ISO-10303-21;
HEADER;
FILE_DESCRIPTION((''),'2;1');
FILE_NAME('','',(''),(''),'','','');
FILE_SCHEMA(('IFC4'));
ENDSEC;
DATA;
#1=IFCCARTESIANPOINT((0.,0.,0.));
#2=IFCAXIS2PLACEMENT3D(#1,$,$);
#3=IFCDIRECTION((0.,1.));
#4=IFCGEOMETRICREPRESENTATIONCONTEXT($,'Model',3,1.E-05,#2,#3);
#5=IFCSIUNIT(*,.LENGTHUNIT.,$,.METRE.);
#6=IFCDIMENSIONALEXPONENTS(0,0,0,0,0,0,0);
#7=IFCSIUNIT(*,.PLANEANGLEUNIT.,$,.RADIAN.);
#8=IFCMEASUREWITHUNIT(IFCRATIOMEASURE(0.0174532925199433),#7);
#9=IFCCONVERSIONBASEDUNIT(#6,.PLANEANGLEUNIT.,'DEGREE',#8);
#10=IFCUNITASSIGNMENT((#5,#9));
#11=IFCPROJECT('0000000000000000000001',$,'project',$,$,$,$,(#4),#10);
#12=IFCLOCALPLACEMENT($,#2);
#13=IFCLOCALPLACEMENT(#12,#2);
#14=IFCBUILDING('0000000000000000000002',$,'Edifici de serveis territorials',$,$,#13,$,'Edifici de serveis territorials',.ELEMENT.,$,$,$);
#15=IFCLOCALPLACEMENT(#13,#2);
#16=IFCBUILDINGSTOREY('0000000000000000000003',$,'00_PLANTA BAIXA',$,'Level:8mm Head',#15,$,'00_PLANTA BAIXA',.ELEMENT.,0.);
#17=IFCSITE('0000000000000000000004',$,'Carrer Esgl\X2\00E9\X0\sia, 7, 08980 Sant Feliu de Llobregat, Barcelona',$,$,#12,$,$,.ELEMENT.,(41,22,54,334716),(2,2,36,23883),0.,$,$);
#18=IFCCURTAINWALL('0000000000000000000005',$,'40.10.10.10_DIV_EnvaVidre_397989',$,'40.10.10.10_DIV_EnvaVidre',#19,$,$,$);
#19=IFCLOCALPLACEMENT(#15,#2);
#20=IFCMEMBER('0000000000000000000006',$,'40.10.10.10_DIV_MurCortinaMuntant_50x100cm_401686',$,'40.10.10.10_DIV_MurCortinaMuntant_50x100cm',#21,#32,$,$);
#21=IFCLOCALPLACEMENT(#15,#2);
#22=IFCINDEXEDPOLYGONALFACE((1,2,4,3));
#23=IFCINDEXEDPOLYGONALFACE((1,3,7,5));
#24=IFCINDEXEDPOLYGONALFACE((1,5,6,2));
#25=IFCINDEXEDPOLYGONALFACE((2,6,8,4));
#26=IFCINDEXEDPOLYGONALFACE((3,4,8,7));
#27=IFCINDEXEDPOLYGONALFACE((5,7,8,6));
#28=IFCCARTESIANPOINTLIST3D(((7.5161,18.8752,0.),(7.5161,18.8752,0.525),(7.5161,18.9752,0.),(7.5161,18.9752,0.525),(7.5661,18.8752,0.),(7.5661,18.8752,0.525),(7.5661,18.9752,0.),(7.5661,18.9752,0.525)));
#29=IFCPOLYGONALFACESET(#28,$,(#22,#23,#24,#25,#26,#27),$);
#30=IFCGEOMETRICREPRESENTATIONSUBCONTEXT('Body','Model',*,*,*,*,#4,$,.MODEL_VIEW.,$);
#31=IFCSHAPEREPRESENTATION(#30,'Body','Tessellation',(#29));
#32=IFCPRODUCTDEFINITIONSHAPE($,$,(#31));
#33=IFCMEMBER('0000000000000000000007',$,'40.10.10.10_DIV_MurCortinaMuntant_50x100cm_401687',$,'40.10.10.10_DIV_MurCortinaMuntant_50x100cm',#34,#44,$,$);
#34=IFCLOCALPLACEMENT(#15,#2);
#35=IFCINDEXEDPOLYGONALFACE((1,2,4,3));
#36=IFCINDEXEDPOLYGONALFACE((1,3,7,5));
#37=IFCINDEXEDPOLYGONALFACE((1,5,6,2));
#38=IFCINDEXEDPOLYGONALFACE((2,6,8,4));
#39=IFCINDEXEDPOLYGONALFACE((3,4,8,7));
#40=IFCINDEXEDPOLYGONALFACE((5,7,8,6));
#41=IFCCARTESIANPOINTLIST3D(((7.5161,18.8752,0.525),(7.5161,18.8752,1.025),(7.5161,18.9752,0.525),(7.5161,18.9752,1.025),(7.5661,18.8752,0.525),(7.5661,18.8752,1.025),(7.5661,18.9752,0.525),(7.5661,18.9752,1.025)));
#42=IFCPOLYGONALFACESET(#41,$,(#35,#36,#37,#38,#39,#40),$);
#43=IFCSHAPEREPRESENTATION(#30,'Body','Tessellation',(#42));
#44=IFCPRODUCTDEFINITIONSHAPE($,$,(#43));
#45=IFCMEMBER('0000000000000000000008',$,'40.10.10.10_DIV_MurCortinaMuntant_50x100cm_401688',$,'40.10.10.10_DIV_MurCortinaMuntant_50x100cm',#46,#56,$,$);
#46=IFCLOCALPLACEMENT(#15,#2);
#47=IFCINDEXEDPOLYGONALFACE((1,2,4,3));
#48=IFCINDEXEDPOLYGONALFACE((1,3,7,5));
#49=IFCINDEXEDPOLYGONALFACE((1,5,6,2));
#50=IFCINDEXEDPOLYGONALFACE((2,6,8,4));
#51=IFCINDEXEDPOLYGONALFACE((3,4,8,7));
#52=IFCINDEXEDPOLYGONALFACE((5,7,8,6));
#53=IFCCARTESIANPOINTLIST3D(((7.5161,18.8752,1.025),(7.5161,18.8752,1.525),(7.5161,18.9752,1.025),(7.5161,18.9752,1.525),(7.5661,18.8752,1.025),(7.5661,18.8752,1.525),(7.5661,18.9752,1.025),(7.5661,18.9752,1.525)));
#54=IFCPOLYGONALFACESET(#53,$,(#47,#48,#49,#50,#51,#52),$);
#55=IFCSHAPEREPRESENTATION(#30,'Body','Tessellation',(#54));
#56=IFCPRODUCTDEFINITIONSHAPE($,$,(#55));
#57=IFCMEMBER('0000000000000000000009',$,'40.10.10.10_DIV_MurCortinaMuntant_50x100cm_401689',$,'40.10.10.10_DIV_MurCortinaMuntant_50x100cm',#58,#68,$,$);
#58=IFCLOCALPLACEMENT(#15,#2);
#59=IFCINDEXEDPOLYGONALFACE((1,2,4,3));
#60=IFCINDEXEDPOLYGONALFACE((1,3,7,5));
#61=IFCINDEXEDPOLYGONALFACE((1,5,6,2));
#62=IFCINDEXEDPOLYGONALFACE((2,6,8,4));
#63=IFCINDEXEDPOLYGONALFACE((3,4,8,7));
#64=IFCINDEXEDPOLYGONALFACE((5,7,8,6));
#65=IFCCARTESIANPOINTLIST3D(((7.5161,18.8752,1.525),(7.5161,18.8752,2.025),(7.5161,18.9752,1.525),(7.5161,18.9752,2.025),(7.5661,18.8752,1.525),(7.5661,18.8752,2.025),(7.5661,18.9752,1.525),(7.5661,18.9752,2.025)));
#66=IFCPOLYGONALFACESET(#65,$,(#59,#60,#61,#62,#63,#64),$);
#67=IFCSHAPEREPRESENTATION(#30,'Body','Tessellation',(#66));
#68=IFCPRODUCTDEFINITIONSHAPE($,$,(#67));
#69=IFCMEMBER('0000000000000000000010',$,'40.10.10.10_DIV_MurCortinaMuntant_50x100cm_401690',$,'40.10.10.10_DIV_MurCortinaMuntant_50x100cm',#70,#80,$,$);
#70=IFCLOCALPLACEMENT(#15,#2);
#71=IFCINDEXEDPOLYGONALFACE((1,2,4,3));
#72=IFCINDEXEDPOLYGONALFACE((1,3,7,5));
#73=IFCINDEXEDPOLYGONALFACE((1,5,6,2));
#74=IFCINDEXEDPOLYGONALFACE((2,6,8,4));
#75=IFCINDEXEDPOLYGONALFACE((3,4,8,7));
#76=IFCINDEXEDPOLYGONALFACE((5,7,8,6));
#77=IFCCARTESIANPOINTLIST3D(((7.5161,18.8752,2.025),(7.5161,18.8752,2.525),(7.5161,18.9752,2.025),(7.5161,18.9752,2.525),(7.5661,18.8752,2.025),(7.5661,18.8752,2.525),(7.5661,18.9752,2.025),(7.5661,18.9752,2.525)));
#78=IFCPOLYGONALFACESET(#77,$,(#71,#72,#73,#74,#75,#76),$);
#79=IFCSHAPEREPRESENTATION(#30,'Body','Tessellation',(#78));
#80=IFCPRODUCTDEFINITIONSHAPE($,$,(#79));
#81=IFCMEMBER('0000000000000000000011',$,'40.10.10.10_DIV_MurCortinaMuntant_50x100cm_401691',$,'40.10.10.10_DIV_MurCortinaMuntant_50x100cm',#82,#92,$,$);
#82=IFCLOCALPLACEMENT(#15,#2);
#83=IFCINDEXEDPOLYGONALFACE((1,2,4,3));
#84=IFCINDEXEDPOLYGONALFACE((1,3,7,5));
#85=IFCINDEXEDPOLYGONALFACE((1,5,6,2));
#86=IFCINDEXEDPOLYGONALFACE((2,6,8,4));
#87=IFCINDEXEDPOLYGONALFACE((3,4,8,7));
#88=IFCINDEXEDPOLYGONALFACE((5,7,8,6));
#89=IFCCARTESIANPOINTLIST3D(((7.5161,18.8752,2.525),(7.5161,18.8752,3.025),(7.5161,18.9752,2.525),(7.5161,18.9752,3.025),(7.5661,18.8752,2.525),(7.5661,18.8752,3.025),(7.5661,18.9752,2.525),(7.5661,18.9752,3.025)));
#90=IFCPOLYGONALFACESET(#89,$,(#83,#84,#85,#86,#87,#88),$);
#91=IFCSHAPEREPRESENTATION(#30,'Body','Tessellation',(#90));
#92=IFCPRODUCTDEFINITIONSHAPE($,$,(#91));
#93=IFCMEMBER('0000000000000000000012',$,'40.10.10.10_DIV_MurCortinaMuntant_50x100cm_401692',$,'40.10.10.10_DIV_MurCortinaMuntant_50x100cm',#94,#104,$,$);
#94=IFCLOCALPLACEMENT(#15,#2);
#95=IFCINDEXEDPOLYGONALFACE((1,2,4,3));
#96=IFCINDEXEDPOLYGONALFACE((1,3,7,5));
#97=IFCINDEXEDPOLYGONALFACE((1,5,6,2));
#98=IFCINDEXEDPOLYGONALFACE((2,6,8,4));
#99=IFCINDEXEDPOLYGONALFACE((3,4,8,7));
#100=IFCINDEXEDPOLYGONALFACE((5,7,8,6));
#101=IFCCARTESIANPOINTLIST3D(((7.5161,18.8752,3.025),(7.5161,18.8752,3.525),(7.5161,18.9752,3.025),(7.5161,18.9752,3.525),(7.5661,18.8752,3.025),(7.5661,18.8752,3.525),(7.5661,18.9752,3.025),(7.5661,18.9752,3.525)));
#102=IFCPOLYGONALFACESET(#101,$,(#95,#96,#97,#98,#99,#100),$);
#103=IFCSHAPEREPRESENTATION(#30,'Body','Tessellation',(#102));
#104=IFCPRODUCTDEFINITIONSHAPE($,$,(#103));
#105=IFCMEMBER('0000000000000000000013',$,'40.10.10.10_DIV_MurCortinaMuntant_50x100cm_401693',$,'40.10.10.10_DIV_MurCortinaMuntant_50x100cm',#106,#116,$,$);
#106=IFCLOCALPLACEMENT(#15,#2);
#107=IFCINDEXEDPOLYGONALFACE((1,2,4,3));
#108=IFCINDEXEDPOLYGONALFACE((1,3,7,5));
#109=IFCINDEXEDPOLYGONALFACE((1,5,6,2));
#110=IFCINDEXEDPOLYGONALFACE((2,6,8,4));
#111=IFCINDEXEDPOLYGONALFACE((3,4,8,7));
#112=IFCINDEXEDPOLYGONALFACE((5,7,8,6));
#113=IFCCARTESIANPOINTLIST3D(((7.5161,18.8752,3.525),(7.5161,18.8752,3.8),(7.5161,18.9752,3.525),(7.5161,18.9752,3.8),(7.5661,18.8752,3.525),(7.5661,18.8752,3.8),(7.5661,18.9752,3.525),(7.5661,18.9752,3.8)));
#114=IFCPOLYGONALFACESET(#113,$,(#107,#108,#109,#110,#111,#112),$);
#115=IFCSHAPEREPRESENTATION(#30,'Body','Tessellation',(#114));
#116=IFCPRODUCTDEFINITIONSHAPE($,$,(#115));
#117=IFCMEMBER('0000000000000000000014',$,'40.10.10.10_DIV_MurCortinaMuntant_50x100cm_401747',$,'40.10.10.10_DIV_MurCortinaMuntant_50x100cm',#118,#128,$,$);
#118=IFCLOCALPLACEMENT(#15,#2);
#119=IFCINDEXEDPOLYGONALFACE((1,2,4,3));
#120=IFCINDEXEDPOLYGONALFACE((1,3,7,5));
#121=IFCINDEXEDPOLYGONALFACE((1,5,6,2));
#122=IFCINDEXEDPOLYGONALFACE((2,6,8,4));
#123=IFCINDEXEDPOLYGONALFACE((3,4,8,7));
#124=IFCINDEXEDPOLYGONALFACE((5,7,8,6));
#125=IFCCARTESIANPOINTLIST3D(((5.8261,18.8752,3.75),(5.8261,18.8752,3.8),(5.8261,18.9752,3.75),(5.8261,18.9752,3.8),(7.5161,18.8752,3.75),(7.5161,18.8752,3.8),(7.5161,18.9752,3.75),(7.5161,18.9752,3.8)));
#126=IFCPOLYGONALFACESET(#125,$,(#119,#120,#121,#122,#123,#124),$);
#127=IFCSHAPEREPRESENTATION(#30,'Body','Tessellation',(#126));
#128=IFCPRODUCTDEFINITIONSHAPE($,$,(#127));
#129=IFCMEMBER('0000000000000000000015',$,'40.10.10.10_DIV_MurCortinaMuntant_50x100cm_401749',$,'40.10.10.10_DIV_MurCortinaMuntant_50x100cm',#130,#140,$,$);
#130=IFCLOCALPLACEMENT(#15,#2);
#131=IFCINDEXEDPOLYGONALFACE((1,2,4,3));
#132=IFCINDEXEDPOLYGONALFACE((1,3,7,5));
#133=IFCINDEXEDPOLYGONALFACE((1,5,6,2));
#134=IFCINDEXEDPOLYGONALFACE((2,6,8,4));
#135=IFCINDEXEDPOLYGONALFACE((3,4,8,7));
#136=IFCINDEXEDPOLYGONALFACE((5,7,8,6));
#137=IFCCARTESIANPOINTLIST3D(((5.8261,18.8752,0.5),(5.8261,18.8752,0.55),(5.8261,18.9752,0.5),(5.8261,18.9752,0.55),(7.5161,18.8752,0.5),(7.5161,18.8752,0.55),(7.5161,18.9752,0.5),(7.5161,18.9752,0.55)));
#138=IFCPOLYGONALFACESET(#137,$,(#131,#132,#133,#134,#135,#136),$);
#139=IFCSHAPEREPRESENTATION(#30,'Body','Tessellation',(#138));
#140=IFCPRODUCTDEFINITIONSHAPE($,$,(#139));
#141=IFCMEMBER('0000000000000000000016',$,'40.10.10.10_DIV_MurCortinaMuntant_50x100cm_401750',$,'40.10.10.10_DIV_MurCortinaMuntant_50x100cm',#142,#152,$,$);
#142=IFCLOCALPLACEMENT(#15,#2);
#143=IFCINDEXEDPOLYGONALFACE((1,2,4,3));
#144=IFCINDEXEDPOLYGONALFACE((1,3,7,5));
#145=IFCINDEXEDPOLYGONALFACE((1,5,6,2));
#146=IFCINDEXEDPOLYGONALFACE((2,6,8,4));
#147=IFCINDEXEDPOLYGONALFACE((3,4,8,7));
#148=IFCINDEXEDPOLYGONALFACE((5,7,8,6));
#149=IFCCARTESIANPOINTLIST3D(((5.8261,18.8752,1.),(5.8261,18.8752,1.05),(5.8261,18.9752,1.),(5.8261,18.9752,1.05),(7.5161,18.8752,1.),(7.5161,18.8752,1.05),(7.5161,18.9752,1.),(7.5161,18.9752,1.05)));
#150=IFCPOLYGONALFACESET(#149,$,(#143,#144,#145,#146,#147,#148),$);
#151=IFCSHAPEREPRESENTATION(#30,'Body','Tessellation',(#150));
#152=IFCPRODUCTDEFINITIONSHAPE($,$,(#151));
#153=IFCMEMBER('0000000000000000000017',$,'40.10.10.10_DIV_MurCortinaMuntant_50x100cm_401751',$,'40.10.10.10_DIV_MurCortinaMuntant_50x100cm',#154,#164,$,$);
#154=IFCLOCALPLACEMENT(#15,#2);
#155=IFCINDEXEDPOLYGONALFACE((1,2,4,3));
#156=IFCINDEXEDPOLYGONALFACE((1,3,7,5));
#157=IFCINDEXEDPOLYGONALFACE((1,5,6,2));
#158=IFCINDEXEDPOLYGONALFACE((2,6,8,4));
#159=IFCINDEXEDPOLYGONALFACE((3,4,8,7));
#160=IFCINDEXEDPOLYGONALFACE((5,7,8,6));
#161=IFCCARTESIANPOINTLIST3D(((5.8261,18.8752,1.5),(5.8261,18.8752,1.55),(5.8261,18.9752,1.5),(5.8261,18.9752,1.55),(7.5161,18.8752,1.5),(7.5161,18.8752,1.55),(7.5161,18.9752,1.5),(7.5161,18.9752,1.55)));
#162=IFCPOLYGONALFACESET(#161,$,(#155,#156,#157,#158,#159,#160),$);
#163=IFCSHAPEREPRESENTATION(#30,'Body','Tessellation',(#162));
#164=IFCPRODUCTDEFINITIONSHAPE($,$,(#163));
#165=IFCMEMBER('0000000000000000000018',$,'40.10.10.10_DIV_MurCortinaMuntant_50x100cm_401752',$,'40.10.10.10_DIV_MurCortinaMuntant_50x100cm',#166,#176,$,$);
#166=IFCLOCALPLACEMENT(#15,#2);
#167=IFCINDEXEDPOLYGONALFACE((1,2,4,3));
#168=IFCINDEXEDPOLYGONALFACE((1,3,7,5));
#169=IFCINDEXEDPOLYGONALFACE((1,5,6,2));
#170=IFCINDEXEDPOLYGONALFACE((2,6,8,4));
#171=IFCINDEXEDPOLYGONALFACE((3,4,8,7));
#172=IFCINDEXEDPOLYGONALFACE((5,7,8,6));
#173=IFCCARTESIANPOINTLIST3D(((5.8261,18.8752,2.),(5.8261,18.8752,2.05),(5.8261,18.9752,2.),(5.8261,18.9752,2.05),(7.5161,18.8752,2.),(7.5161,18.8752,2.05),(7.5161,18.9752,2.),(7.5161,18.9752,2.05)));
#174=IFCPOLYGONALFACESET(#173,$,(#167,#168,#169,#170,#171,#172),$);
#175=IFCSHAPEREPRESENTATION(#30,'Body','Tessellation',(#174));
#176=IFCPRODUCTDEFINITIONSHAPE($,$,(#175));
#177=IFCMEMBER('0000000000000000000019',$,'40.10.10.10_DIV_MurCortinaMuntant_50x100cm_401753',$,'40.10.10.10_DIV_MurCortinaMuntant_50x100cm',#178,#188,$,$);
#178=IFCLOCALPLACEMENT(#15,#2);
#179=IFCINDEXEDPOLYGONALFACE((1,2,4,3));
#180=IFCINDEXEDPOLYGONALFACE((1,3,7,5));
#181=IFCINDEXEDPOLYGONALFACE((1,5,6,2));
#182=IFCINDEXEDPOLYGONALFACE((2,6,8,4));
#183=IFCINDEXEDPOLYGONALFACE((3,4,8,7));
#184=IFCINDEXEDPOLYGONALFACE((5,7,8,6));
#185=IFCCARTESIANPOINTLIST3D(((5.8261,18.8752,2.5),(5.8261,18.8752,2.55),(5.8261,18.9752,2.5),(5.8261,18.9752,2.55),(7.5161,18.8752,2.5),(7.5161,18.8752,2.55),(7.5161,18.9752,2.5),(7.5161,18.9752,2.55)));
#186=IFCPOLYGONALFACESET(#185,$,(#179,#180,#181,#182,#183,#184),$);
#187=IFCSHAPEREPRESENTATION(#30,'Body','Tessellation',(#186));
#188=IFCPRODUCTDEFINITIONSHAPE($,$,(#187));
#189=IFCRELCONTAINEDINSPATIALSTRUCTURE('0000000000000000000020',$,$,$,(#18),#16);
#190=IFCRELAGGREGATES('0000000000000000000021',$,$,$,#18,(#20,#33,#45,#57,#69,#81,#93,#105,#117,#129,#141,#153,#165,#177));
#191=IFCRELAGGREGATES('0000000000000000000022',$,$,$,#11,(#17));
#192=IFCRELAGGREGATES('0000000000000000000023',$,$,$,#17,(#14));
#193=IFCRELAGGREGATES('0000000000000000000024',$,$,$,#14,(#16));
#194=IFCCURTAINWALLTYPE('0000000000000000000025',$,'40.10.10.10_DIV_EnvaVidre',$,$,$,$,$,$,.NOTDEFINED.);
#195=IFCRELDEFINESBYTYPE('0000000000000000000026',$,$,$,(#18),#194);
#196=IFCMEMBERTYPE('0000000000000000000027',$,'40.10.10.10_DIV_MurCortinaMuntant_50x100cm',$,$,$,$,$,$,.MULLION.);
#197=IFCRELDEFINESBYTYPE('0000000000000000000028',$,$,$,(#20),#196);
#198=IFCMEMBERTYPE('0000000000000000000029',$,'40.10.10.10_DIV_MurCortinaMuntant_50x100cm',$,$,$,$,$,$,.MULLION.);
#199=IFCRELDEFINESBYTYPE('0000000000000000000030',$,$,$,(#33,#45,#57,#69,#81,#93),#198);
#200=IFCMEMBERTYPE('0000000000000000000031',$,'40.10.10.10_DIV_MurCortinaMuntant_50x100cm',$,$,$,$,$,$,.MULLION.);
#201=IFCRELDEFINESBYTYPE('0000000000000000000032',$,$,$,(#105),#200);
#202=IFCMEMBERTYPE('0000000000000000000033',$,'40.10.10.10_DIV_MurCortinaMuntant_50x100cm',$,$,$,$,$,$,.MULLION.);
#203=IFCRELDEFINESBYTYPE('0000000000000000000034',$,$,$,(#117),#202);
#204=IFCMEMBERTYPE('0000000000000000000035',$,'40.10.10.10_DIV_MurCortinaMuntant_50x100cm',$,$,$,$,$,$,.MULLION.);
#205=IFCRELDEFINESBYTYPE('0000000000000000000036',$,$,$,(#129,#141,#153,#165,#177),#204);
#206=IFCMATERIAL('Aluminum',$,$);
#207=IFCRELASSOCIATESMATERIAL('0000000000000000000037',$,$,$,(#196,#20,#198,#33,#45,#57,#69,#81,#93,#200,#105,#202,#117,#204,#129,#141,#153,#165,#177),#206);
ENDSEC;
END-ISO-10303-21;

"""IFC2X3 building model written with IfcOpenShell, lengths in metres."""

from ifc_helpers import new_model, entity, si_unit, converted_unit, direction, frame, origin, origin_2d_with_axis, place, context, subcontext, project, spatial, rectangle, extrude, source, transform, mapped, material, type_object, type_shapes, element, aggregate, save


model = new_model("IFC2X3")

# Units and contexts
model_context = context("Model", 3, precision=1e-05, world=origin(), true_north=direction((0.0, 1.0)))
body_context = subcontext(model_context, "Body", "Model", "MODEL_VIEW")
ifc_project = project(units=[si_unit("LENGTHUNIT", "METRE"), converted_unit("PLANEANGLEUNIT", "DEGREE", entity("IfcRatioMeasure", 0.0174532925199433), si_unit("PLANEANGLEUNIT", "RADIAN"), dimensions=[0, 0, 0, 0, 0, 0, 0])], contexts=[model_context])

# Site, building, storey
site_placement = place(None, origin())
site = spatial("IfcSite", under=ifc_project, at=site_placement, Name="Carrer Església, 7, 08980 Sant Feliu de Llobregat, Barcelona", CompositionType="ELEMENT", RefLatitude=(41, 22, 54, 334716), RefLongitude=(2, 2, 36, 23883), RefElevation=0.0)
building_placement = place(site_placement, origin())
building = spatial("IfcBuilding", under=site, at=building_placement, Name="Edifici de serveis territorials", LongName="Edifici de serveis territorials", CompositionType="ELEMENT")
storey_placement = place(building_placement, origin())
storey = spatial("IfcBuildingStorey", under=building, at=storey_placement, Name="00_PLANTA BAIXA", ObjectType="Level:8mm Head", LongName="00_PLANTA BAIXA", CompositionType="ELEMENT", Elevation=0.0)

# Curtain wall, members
curtain_wall_type = type_object("IfcCurtainWallType", Name="40.10.10.10_DIV_EnvaVidre", PredefinedType="NOTDEFINED")
curtain_wall_1_placement = place(storey_placement, origin())
curtain_wall_1 = element("IfcCurtainWall", 1, at=curtain_wall_1_placement, inside=storey, type_object=curtain_wall_type, Name="40.10.10.10_DIV_EnvaVidre_397989", ObjectType="40.10.10.10_DIV_EnvaVidre")
ifc_material_1 = material(Name="Aluminum")
member_type_1 = type_object("IfcMemberType", Name="40.10.10.10_DIV_MurCortinaMuntant_50x100cm", PredefinedType="MULLION", material=ifc_material_1)
shared_shape_1 = source(origin(), body_context, "Body", "SweptSolid", [
    extrude(rectangle(XDim=0.1, YDim=0.05, at=origin_2d_with_axis()), frame((-0.025, 0.0, -0.525), z_axis=(0.0, 0.0, 1.0), x_axis=(0.0, -1.0, 0.0)), (0.0, 0.0, 1.0), 0.525),
])
type_shapes(member_type_1, [shared_shape_1])
member_1_placement = place(storey_placement, frame((7.5661, 18.9252, 0.0), z_axis=(0.0, 0.0, -1.0), x_axis=(1.0, 0.0, 0.0)))
member_1 = element("IfcMember", 2, at=member_1_placement, type_object=member_type_1, material=ifc_material_1, Name="40.10.10.10_DIV_MurCortinaMuntant_50x100cm_401686", ObjectType="40.10.10.10_DIV_MurCortinaMuntant_50x100cm", context=body_context, shape_type="MappedRepresentation", body=[
    mapped(shared_shape_1, transform((0.0, 0.0, 0.0), scale=1.0)),
])
member_type_2 = type_object("IfcMemberType", Name="40.10.10.10_DIV_MurCortinaMuntant_50x100cm", PredefinedType="MULLION", material=ifc_material_1)
shared_shape_2 = source(origin(), body_context, "Body", "SweptSolid", [
    extrude(rectangle(XDim=0.1, YDim=0.05, at=origin_2d_with_axis()), frame((-0.025, 0.0, -0.5), z_axis=(0.0, 0.0, 1.0), x_axis=(0.0, -1.0, 0.0)), (0.0, 0.0, 1.0), 0.5),
])
type_shapes(member_type_2, [shared_shape_2])
member_2_placement = place(storey_placement, frame((7.5661, 18.9252, 0.525), z_axis=(0.0, 0.0, -1.0), x_axis=(1.0, 0.0, 0.0)))
member_2 = element("IfcMember", 3, at=member_2_placement, type_object=member_type_2, material=ifc_material_1, Name="40.10.10.10_DIV_MurCortinaMuntant_50x100cm_401687", ObjectType="40.10.10.10_DIV_MurCortinaMuntant_50x100cm", context=body_context, shape_type="MappedRepresentation", body=[
    mapped(shared_shape_2, transform((0.0, 0.0, 0.0), scale=1.0)),
])
member_3_placement = place(storey_placement, frame((7.5661, 18.9252, 1.025), z_axis=(0.0, 0.0, -1.0), x_axis=(1.0, 0.0, 0.0)))
member_3 = element("IfcMember", 4, at=member_3_placement, type_object=member_type_2, material=ifc_material_1, Name="40.10.10.10_DIV_MurCortinaMuntant_50x100cm_401688", ObjectType="40.10.10.10_DIV_MurCortinaMuntant_50x100cm", context=body_context, shape_type="MappedRepresentation", body=[
    mapped(shared_shape_2, transform((0.0, 0.0, 0.0), scale=1.0)),
])
member_4_placement = place(storey_placement, frame((7.5661, 18.9252, 1.525), z_axis=(0.0, 0.0, -1.0), x_axis=(1.0, 0.0, 0.0)))
member_4 = element("IfcMember", 5, at=member_4_placement, type_object=member_type_2, material=ifc_material_1, Name="40.10.10.10_DIV_MurCortinaMuntant_50x100cm_401689", ObjectType="40.10.10.10_DIV_MurCortinaMuntant_50x100cm", context=body_context, shape_type="MappedRepresentation", body=[
    mapped(shared_shape_2, transform((0.0, 0.0, 0.0), scale=1.0)),
])
member_5_placement = place(storey_placement, frame((7.5661, 18.9252, 2.025), z_axis=(0.0, 0.0, -1.0), x_axis=(1.0, 0.0, 0.0)))
member_5 = element("IfcMember", 6, at=member_5_placement, type_object=member_type_2, material=ifc_material_1, Name="40.10.10.10_DIV_MurCortinaMuntant_50x100cm_401690", ObjectType="40.10.10.10_DIV_MurCortinaMuntant_50x100cm", context=body_context, shape_type="MappedRepresentation", body=[
    mapped(shared_shape_2, transform((0.0, 0.0, 0.0), scale=1.0)),
])
member_6_placement = place(storey_placement, frame((7.5661, 18.9252, 2.525), z_axis=(0.0, 0.0, -1.0), x_axis=(1.0, 0.0, 0.0)))
member_6 = element("IfcMember", 7, at=member_6_placement, type_object=member_type_2, material=ifc_material_1, Name="40.10.10.10_DIV_MurCortinaMuntant_50x100cm_401691", ObjectType="40.10.10.10_DIV_MurCortinaMuntant_50x100cm", context=body_context, shape_type="MappedRepresentation", body=[
    mapped(shared_shape_2, transform((0.0, 0.0, 0.0), scale=1.0)),
])
member_7_placement = place(storey_placement, frame((7.5661, 18.9252, 3.025), z_axis=(0.0, 0.0, -1.0), x_axis=(1.0, 0.0, 0.0)))
member_7 = element("IfcMember", 8, at=member_7_placement, type_object=member_type_2, material=ifc_material_1, Name="40.10.10.10_DIV_MurCortinaMuntant_50x100cm_401692", ObjectType="40.10.10.10_DIV_MurCortinaMuntant_50x100cm", context=body_context, shape_type="MappedRepresentation", body=[
    mapped(shared_shape_2, transform((0.0, 0.0, 0.0), scale=1.0)),
])
member_type_3 = type_object("IfcMemberType", Name="40.10.10.10_DIV_MurCortinaMuntant_50x100cm", PredefinedType="MULLION", material=ifc_material_1)
shared_shape_3 = source(origin(), body_context, "Body", "SweptSolid", [
    extrude(rectangle(XDim=0.1, YDim=0.05, at=origin_2d_with_axis()), frame((-0.025, 0.0, -0.275), z_axis=(0.0, 0.0, 1.0), x_axis=(0.0, -1.0, 0.0)), (0.0, 0.0, 1.0), 0.275),
])
type_shapes(member_type_3, [shared_shape_3])
member_8_placement = place(storey_placement, frame((7.5661, 18.9252, 3.525), z_axis=(0.0, 0.0, -1.0), x_axis=(1.0, 0.0, 0.0)))
member_8 = element("IfcMember", 9, at=member_8_placement, type_object=member_type_3, material=ifc_material_1, Name="40.10.10.10_DIV_MurCortinaMuntant_50x100cm_401693", ObjectType="40.10.10.10_DIV_MurCortinaMuntant_50x100cm", context=body_context, shape_type="MappedRepresentation", body=[
    mapped(shared_shape_3, transform((0.0, 0.0, 0.0), scale=1.0)),
])
member_type_4 = type_object("IfcMemberType", Name="40.10.10.10_DIV_MurCortinaMuntant_50x100cm", PredefinedType="MULLION", material=ifc_material_1)
shared_shape_4 = source(origin(), body_context, "Body", "SweptSolid", [
    extrude(rectangle(XDim=0.1, YDim=0.05, at=origin_2d_with_axis()), frame((-0.025, 0.0, -1.69), z_axis=(0.0, 0.0, 1.0), x_axis=(0.0, -1.0, 0.0)), (0.0, 0.0, 1.0), 1.69),
])
type_shapes(member_type_4, [shared_shape_4])
member_9_placement = place(storey_placement, frame((7.5161, 18.9252, 3.8), z_axis=(1.0, 0.0, 0.0), x_axis=(0.0, 0.0, 1.0)))
member_9 = element("IfcMember", 10, at=member_9_placement, type_object=member_type_4, material=ifc_material_1, Name="40.10.10.10_DIV_MurCortinaMuntant_50x100cm_401747", ObjectType="40.10.10.10_DIV_MurCortinaMuntant_50x100cm", context=body_context, shape_type="MappedRepresentation", body=[
    mapped(shared_shape_4, transform((0.0, 0.0, 0.0), scale=1.0)),
])
member_type_5 = type_object("IfcMemberType", Name="40.10.10.10_DIV_MurCortinaMuntant_50x100cm", PredefinedType="MULLION", material=ifc_material_1)
shared_shape_5 = source(origin(), body_context, "Body", "SweptSolid", [
    extrude(rectangle(XDim=0.1, YDim=0.05, at=origin_2d_with_axis()), frame((0.0, 0.0, -1.69), z_axis=(0.0, 0.0, 1.0), x_axis=(0.0, -1.0, 0.0)), (0.0, 0.0, 1.0), 1.69),
])
type_shapes(member_type_5, [shared_shape_5])
member_10_placement = place(storey_placement, frame((7.5161, 18.9252, 0.525), z_axis=(1.0, 0.0, 0.0), x_axis=(0.0, 0.0, 1.0)))
member_10 = element("IfcMember", 11, at=member_10_placement, type_object=member_type_5, material=ifc_material_1, Name="40.10.10.10_DIV_MurCortinaMuntant_50x100cm_401749", ObjectType="40.10.10.10_DIV_MurCortinaMuntant_50x100cm", context=body_context, shape_type="MappedRepresentation", body=[
    mapped(shared_shape_5, transform((0.0, 0.0, 0.0), scale=1.0)),
])
member_11_placement = place(storey_placement, frame((7.5161, 18.9252, 1.025), z_axis=(1.0, 0.0, 0.0), x_axis=(0.0, 0.0, 1.0)))
member_11 = element("IfcMember", 12, at=member_11_placement, type_object=member_type_5, material=ifc_material_1, Name="40.10.10.10_DIV_MurCortinaMuntant_50x100cm_401750", ObjectType="40.10.10.10_DIV_MurCortinaMuntant_50x100cm", context=body_context, shape_type="MappedRepresentation", body=[
    mapped(shared_shape_5, transform((0.0, 0.0, 0.0), scale=1.0)),
])
member_12_placement = place(storey_placement, frame((7.5161, 18.9252, 1.525), z_axis=(1.0, 0.0, 0.0), x_axis=(0.0, 0.0, 1.0)))
member_12 = element("IfcMember", 13, at=member_12_placement, type_object=member_type_5, material=ifc_material_1, Name="40.10.10.10_DIV_MurCortinaMuntant_50x100cm_401751", ObjectType="40.10.10.10_DIV_MurCortinaMuntant_50x100cm", context=body_context, shape_type="MappedRepresentation", body=[
    mapped(shared_shape_5, transform((0.0, 0.0, 0.0), scale=1.0)),
])
member_13_placement = place(storey_placement, frame((7.5161, 18.9252, 2.025), z_axis=(1.0, 0.0, 0.0), x_axis=(0.0, 0.0, 1.0)))
member_13 = element("IfcMember", 14, at=member_13_placement, type_object=member_type_5, material=ifc_material_1, Name="40.10.10.10_DIV_MurCortinaMuntant_50x100cm_401752", ObjectType="40.10.10.10_DIV_MurCortinaMuntant_50x100cm", context=body_context, shape_type="MappedRepresentation", body=[
    mapped(shared_shape_5, transform((0.0, 0.0, 0.0), scale=1.0)),
])
member_14_placement = place(storey_placement, frame((7.5161, 18.9252, 2.525), z_axis=(1.0, 0.0, 0.0), x_axis=(0.0, 0.0, 1.0)))
member_14 = element("IfcMember", 15, at=member_14_placement, type_object=member_type_5, material=ifc_material_1, Name="40.10.10.10_DIV_MurCortinaMuntant_50x100cm_401753", ObjectType="40.10.10.10_DIV_MurCortinaMuntant_50x100cm", context=body_context, shape_type="MappedRepresentation", body=[
    mapped(shared_shape_5, transform((0.0, 0.0, 0.0), scale=1.0)),
])

aggregate(curtain_wall_1, [member_1, member_2, member_3, member_4, member_5, member_6, member_7, member_8, member_9, member_10, member_11, member_12, member_13, member_14])

save(model, "model.ifc")
